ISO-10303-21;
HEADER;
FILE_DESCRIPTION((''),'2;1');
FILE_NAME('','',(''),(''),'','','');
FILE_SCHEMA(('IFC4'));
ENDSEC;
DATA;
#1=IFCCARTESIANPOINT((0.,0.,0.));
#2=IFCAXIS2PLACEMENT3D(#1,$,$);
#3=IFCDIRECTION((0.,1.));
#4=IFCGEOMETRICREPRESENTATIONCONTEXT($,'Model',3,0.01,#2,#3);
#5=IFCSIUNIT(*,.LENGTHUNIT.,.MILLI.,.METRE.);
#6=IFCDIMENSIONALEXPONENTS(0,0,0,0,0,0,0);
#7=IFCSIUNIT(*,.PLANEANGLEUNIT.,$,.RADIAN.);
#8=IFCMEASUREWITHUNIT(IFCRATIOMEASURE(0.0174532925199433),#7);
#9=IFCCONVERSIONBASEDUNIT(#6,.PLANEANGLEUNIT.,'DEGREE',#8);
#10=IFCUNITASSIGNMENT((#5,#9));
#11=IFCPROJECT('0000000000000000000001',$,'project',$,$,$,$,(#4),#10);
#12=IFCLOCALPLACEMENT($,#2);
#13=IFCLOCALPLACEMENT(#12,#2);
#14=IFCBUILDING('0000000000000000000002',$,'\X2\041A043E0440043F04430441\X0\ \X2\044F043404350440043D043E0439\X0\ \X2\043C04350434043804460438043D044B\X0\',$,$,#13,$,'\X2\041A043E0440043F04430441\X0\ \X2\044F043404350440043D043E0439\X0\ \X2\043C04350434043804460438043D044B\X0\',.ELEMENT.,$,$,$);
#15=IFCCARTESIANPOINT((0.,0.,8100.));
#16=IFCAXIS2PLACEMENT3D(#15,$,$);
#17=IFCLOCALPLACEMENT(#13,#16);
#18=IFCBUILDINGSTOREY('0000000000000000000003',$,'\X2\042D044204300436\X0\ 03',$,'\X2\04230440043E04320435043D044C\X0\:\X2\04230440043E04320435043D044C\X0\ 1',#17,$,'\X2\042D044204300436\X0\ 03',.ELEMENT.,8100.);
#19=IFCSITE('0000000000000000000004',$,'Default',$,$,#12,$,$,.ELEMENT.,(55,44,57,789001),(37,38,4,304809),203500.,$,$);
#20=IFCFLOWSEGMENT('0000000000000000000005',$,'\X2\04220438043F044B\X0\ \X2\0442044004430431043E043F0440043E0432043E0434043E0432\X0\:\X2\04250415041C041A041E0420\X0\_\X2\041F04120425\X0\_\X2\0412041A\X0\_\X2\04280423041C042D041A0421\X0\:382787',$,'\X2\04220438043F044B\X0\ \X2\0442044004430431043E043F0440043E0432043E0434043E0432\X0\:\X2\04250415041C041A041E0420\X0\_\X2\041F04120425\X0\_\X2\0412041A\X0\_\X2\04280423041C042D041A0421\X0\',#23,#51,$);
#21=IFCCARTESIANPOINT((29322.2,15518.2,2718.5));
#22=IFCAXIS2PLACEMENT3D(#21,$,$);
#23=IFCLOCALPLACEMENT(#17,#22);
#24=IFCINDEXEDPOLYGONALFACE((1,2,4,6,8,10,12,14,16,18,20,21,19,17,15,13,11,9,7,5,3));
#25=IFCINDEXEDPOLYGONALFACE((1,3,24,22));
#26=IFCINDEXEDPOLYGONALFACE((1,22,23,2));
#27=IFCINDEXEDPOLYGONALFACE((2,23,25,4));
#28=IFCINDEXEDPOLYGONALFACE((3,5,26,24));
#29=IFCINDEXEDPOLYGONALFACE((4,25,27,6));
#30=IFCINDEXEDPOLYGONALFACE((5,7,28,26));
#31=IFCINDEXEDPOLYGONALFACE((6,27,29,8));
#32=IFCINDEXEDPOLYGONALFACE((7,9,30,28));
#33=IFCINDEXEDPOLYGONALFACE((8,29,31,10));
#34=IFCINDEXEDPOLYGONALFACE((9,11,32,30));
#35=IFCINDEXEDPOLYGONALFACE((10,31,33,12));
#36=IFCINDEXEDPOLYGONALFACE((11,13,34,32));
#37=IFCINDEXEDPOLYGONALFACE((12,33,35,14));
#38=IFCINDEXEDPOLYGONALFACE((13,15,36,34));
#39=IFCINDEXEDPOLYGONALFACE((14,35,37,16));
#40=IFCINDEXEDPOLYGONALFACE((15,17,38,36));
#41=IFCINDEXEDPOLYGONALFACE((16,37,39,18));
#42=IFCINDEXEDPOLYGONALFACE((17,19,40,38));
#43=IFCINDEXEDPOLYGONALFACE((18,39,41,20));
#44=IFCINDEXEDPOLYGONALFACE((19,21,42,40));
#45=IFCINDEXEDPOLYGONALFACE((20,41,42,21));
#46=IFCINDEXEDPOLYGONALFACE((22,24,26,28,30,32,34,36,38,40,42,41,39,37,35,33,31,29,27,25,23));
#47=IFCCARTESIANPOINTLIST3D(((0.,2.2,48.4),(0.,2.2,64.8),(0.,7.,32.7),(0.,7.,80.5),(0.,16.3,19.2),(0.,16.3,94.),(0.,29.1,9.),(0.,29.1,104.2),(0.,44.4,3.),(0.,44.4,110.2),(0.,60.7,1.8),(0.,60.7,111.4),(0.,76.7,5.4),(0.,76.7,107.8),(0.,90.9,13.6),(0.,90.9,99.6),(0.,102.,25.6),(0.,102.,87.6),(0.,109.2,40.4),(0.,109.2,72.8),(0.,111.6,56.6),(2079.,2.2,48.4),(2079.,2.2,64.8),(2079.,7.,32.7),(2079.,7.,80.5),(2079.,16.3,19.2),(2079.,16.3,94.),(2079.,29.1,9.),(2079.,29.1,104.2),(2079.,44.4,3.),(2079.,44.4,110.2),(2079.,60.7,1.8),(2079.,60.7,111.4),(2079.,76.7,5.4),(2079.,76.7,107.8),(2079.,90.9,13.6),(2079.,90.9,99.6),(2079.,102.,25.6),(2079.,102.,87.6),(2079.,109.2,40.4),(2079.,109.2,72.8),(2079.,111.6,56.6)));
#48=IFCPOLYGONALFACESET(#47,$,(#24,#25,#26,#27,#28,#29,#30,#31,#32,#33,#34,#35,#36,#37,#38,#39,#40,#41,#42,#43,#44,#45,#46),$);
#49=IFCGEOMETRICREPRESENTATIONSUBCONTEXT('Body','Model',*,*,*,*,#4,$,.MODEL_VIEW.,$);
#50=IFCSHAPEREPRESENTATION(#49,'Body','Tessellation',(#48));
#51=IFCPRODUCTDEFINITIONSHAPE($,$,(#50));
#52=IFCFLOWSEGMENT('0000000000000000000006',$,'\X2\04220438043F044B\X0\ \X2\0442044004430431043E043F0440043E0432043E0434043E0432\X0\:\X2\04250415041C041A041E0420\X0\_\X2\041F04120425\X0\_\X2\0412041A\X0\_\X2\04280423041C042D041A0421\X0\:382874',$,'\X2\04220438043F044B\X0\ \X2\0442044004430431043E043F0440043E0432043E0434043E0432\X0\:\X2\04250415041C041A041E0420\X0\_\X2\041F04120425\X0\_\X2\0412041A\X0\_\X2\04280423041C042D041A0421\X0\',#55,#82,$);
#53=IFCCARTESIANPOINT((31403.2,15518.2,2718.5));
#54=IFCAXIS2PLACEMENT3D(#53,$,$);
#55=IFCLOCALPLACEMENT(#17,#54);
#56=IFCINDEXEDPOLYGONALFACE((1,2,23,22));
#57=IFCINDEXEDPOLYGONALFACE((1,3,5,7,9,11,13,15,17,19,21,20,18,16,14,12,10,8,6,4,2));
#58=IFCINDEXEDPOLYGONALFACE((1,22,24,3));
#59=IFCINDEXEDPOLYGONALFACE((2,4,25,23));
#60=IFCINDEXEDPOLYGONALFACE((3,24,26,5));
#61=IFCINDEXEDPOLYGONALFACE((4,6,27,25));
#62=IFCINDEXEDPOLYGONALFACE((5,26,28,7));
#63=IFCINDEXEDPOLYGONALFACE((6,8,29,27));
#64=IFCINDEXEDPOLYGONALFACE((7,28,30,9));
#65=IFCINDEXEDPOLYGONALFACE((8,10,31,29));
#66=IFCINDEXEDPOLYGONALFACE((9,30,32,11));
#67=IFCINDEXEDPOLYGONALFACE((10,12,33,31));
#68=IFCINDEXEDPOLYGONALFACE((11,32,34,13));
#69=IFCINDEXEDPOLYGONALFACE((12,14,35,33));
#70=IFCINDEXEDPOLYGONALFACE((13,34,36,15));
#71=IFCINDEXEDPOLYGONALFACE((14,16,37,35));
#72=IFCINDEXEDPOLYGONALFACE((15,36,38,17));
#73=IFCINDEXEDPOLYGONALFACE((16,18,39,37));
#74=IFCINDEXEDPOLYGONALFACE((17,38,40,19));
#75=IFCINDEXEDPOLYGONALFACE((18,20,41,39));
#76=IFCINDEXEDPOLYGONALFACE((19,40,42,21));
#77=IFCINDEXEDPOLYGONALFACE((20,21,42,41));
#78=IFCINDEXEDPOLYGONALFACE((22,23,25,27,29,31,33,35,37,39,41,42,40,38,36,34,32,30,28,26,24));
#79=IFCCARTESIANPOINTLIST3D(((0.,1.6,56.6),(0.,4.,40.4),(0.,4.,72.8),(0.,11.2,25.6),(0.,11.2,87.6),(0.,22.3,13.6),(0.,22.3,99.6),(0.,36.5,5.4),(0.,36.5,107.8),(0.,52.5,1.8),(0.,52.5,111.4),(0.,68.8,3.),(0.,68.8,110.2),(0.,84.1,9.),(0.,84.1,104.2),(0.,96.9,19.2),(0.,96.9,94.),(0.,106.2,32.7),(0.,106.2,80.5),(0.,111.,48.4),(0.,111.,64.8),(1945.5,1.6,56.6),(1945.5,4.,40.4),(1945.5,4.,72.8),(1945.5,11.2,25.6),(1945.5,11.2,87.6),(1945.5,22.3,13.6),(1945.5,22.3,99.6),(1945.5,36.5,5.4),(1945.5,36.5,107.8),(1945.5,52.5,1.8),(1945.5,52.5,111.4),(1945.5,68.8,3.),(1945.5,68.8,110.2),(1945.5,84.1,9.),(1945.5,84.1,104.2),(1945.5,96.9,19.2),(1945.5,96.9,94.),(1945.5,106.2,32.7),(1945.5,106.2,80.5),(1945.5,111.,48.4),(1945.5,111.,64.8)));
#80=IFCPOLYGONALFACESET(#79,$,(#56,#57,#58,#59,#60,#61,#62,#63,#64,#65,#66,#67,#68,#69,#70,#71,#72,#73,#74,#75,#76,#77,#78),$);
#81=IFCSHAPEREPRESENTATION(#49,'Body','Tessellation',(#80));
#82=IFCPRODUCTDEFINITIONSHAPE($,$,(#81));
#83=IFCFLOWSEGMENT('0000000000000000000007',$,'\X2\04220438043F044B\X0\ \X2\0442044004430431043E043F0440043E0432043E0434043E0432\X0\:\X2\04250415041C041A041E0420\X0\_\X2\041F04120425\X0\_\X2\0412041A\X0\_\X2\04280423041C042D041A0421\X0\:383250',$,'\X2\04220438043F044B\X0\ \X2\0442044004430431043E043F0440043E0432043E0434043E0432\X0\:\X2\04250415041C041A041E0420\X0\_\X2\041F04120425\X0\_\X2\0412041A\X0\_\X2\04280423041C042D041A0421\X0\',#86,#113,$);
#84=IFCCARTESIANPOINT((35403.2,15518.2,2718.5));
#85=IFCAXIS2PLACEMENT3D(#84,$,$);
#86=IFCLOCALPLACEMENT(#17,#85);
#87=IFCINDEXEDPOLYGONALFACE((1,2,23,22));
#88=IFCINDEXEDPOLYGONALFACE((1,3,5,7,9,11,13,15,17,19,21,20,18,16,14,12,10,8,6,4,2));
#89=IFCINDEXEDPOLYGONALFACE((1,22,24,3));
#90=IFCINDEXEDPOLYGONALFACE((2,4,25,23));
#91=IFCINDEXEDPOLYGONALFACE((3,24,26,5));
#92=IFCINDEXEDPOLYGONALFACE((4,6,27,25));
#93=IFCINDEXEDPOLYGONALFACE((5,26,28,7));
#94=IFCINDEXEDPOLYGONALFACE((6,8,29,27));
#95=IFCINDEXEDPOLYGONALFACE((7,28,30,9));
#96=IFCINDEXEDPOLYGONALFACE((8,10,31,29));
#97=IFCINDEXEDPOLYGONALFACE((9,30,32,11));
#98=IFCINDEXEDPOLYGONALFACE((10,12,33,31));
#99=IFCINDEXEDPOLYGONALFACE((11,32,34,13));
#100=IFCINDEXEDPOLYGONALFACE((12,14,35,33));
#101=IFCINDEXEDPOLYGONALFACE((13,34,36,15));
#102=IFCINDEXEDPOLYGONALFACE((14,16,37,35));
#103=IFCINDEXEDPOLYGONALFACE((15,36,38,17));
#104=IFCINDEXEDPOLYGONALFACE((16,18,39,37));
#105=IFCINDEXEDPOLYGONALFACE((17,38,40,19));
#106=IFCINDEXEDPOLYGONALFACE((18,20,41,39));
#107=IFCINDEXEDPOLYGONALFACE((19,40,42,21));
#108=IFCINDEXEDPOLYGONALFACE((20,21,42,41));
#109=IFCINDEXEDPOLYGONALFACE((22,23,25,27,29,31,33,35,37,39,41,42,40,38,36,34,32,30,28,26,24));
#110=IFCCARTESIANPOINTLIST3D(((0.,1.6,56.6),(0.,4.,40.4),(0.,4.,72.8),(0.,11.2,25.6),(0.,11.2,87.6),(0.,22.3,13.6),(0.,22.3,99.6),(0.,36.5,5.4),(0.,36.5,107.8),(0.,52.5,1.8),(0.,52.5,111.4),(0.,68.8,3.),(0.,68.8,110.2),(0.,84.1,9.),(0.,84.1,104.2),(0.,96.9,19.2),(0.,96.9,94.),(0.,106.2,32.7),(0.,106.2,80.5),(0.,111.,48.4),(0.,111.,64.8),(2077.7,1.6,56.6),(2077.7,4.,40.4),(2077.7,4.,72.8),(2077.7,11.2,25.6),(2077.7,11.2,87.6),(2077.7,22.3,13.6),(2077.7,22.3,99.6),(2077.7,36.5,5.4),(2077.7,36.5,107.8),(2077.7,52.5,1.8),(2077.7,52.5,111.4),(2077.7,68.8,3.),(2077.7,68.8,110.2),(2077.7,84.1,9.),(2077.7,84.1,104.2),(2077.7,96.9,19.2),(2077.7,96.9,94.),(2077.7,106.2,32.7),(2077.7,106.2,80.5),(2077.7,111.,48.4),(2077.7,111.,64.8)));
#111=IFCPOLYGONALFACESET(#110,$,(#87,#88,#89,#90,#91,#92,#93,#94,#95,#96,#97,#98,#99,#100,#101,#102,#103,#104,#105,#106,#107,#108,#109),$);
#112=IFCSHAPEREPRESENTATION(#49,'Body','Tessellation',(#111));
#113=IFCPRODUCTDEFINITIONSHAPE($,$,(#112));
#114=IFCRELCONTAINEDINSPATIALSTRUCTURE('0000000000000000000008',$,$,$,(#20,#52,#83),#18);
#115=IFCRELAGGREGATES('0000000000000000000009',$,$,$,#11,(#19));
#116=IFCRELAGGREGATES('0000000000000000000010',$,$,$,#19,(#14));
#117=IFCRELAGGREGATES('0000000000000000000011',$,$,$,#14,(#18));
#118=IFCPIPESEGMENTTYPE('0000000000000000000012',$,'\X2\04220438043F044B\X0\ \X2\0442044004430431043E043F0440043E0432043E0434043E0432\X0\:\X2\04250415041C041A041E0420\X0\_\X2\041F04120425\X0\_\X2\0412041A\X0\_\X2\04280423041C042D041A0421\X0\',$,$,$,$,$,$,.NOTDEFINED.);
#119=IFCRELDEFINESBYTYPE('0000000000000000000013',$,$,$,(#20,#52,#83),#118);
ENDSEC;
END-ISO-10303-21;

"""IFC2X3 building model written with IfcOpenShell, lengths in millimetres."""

from ifc_helpers import new_model, entity, si_unit, converted_unit, direction, frame, origin, origin_2d_with_axis, place, context, subcontext, project, spatial, circle, extrude, type_object, element, save


model = new_model("IFC2X3")

# Units and contexts
model_context = context("Model", 3, precision=0.01, world=origin(), true_north=direction((0.0, 1.0)))
body_context = subcontext(model_context, "Body", "Model", "MODEL_VIEW")
ifc_project = project(units=[si_unit("LENGTHUNIT", "METRE", prefix="MILLI"), converted_unit("PLANEANGLEUNIT", "DEGREE", entity("IfcRatioMeasure", 0.0174532925199433), si_unit("PLANEANGLEUNIT", "RADIAN"), dimensions=[0, 0, 0, 0, 0, 0, 0])], contexts=[model_context])

# Site, building, storey
site_placement = place(None, origin())
site = spatial("IfcSite", under=ifc_project, at=site_placement, Name="Default", CompositionType="ELEMENT", RefLatitude=(55, 44, 57, 789001), RefLongitude=(37, 38, 4, 304809), RefElevation=203500.0)
building_placement = place(site_placement, origin())
building = spatial("IfcBuilding", under=site, at=building_placement, Name="Корпус ядерной медицины", LongName="Корпус ядерной медицины", CompositionType="ELEMENT")
storey_placement = place(building_placement, frame((0.0, 0.0, 8100.0)))
storey = spatial("IfcBuildingStorey", under=building, at=storey_placement, Name="Этаж 03", ObjectType="Уровень:Уровень 1", LongName="Этаж 03", CompositionType="ELEMENT", Elevation=8100.0)

# Flow segments
pipe_segment_type = type_object("IfcPipeSegmentType", Name="Типы трубопроводов:ХЕМКОР_ПВХ_ВК_ШУМЭКС", PredefinedType="NOTDEFINED")
flow_segment_1_placement = place(storey_placement, frame((29322.2, 15518.2, 2718.5)))
element("IfcFlowSegment", 1, at=flow_segment_1_placement, inside=storey, type_object=pipe_segment_type, Name="Типы трубопроводов:ХЕМКОР_ПВХ_ВК_ШУМЭКС:382787", ObjectType="Типы трубопроводов:ХЕМКОР_ПВХ_ВК_ШУМЭКС", context=body_context, shape_type="SweptSolid", body=[
    extrude(circle(Radius=55.0, at=origin_2d_with_axis()), frame((0.0, 56.6, 56.6), z_axis=(1.0, 0.0, 0.0), x_axis=(0.0, 1.0, 0.0)), (0.0, 0.0, 1.0), 2079.0),
])
flow_segment_2_placement = place(storey_placement, frame((31403.2, 15518.2, 2718.5)))
element("IfcFlowSegment", 2, at=flow_segment_2_placement, inside=storey, type_object=pipe_segment_type, Name="Типы трубопроводов:ХЕМКОР_ПВХ_ВК_ШУМЭКС:382874", ObjectType="Типы трубопроводов:ХЕМКОР_ПВХ_ВК_ШУМЭКС", context=body_context, shape_type="SweptSolid", body=[
    extrude(circle(Radius=55.0, at=origin_2d_with_axis()), frame((0.0, 56.6, 56.6), z_axis=(1.0, 0.0, 0.0), x_axis=(0.0, -1.0, 0.0)), (0.0, 0.0, 1.0), 1945.5),
])
flow_segment_3_placement = place(storey_placement, frame((35403.2, 15518.2, 2718.5)))
element("IfcFlowSegment", 3, at=flow_segment_3_placement, inside=storey, type_object=pipe_segment_type, Name="Типы трубопроводов:ХЕМКОР_ПВХ_ВК_ШУМЭКС:383250", ObjectType="Типы трубопроводов:ХЕМКОР_ПВХ_ВК_ШУМЭКС", context=body_context, shape_type="SweptSolid", body=[
    extrude(circle(Radius=55.0, at=origin_2d_with_axis()), frame((0.0, 56.6, 56.6), z_axis=(1.0, 0.0, 0.0), x_axis=(0.0, -1.0, 0.0)), (0.0, 0.0, 1.0), 2077.7),
])

save(model, "model.ifc")
